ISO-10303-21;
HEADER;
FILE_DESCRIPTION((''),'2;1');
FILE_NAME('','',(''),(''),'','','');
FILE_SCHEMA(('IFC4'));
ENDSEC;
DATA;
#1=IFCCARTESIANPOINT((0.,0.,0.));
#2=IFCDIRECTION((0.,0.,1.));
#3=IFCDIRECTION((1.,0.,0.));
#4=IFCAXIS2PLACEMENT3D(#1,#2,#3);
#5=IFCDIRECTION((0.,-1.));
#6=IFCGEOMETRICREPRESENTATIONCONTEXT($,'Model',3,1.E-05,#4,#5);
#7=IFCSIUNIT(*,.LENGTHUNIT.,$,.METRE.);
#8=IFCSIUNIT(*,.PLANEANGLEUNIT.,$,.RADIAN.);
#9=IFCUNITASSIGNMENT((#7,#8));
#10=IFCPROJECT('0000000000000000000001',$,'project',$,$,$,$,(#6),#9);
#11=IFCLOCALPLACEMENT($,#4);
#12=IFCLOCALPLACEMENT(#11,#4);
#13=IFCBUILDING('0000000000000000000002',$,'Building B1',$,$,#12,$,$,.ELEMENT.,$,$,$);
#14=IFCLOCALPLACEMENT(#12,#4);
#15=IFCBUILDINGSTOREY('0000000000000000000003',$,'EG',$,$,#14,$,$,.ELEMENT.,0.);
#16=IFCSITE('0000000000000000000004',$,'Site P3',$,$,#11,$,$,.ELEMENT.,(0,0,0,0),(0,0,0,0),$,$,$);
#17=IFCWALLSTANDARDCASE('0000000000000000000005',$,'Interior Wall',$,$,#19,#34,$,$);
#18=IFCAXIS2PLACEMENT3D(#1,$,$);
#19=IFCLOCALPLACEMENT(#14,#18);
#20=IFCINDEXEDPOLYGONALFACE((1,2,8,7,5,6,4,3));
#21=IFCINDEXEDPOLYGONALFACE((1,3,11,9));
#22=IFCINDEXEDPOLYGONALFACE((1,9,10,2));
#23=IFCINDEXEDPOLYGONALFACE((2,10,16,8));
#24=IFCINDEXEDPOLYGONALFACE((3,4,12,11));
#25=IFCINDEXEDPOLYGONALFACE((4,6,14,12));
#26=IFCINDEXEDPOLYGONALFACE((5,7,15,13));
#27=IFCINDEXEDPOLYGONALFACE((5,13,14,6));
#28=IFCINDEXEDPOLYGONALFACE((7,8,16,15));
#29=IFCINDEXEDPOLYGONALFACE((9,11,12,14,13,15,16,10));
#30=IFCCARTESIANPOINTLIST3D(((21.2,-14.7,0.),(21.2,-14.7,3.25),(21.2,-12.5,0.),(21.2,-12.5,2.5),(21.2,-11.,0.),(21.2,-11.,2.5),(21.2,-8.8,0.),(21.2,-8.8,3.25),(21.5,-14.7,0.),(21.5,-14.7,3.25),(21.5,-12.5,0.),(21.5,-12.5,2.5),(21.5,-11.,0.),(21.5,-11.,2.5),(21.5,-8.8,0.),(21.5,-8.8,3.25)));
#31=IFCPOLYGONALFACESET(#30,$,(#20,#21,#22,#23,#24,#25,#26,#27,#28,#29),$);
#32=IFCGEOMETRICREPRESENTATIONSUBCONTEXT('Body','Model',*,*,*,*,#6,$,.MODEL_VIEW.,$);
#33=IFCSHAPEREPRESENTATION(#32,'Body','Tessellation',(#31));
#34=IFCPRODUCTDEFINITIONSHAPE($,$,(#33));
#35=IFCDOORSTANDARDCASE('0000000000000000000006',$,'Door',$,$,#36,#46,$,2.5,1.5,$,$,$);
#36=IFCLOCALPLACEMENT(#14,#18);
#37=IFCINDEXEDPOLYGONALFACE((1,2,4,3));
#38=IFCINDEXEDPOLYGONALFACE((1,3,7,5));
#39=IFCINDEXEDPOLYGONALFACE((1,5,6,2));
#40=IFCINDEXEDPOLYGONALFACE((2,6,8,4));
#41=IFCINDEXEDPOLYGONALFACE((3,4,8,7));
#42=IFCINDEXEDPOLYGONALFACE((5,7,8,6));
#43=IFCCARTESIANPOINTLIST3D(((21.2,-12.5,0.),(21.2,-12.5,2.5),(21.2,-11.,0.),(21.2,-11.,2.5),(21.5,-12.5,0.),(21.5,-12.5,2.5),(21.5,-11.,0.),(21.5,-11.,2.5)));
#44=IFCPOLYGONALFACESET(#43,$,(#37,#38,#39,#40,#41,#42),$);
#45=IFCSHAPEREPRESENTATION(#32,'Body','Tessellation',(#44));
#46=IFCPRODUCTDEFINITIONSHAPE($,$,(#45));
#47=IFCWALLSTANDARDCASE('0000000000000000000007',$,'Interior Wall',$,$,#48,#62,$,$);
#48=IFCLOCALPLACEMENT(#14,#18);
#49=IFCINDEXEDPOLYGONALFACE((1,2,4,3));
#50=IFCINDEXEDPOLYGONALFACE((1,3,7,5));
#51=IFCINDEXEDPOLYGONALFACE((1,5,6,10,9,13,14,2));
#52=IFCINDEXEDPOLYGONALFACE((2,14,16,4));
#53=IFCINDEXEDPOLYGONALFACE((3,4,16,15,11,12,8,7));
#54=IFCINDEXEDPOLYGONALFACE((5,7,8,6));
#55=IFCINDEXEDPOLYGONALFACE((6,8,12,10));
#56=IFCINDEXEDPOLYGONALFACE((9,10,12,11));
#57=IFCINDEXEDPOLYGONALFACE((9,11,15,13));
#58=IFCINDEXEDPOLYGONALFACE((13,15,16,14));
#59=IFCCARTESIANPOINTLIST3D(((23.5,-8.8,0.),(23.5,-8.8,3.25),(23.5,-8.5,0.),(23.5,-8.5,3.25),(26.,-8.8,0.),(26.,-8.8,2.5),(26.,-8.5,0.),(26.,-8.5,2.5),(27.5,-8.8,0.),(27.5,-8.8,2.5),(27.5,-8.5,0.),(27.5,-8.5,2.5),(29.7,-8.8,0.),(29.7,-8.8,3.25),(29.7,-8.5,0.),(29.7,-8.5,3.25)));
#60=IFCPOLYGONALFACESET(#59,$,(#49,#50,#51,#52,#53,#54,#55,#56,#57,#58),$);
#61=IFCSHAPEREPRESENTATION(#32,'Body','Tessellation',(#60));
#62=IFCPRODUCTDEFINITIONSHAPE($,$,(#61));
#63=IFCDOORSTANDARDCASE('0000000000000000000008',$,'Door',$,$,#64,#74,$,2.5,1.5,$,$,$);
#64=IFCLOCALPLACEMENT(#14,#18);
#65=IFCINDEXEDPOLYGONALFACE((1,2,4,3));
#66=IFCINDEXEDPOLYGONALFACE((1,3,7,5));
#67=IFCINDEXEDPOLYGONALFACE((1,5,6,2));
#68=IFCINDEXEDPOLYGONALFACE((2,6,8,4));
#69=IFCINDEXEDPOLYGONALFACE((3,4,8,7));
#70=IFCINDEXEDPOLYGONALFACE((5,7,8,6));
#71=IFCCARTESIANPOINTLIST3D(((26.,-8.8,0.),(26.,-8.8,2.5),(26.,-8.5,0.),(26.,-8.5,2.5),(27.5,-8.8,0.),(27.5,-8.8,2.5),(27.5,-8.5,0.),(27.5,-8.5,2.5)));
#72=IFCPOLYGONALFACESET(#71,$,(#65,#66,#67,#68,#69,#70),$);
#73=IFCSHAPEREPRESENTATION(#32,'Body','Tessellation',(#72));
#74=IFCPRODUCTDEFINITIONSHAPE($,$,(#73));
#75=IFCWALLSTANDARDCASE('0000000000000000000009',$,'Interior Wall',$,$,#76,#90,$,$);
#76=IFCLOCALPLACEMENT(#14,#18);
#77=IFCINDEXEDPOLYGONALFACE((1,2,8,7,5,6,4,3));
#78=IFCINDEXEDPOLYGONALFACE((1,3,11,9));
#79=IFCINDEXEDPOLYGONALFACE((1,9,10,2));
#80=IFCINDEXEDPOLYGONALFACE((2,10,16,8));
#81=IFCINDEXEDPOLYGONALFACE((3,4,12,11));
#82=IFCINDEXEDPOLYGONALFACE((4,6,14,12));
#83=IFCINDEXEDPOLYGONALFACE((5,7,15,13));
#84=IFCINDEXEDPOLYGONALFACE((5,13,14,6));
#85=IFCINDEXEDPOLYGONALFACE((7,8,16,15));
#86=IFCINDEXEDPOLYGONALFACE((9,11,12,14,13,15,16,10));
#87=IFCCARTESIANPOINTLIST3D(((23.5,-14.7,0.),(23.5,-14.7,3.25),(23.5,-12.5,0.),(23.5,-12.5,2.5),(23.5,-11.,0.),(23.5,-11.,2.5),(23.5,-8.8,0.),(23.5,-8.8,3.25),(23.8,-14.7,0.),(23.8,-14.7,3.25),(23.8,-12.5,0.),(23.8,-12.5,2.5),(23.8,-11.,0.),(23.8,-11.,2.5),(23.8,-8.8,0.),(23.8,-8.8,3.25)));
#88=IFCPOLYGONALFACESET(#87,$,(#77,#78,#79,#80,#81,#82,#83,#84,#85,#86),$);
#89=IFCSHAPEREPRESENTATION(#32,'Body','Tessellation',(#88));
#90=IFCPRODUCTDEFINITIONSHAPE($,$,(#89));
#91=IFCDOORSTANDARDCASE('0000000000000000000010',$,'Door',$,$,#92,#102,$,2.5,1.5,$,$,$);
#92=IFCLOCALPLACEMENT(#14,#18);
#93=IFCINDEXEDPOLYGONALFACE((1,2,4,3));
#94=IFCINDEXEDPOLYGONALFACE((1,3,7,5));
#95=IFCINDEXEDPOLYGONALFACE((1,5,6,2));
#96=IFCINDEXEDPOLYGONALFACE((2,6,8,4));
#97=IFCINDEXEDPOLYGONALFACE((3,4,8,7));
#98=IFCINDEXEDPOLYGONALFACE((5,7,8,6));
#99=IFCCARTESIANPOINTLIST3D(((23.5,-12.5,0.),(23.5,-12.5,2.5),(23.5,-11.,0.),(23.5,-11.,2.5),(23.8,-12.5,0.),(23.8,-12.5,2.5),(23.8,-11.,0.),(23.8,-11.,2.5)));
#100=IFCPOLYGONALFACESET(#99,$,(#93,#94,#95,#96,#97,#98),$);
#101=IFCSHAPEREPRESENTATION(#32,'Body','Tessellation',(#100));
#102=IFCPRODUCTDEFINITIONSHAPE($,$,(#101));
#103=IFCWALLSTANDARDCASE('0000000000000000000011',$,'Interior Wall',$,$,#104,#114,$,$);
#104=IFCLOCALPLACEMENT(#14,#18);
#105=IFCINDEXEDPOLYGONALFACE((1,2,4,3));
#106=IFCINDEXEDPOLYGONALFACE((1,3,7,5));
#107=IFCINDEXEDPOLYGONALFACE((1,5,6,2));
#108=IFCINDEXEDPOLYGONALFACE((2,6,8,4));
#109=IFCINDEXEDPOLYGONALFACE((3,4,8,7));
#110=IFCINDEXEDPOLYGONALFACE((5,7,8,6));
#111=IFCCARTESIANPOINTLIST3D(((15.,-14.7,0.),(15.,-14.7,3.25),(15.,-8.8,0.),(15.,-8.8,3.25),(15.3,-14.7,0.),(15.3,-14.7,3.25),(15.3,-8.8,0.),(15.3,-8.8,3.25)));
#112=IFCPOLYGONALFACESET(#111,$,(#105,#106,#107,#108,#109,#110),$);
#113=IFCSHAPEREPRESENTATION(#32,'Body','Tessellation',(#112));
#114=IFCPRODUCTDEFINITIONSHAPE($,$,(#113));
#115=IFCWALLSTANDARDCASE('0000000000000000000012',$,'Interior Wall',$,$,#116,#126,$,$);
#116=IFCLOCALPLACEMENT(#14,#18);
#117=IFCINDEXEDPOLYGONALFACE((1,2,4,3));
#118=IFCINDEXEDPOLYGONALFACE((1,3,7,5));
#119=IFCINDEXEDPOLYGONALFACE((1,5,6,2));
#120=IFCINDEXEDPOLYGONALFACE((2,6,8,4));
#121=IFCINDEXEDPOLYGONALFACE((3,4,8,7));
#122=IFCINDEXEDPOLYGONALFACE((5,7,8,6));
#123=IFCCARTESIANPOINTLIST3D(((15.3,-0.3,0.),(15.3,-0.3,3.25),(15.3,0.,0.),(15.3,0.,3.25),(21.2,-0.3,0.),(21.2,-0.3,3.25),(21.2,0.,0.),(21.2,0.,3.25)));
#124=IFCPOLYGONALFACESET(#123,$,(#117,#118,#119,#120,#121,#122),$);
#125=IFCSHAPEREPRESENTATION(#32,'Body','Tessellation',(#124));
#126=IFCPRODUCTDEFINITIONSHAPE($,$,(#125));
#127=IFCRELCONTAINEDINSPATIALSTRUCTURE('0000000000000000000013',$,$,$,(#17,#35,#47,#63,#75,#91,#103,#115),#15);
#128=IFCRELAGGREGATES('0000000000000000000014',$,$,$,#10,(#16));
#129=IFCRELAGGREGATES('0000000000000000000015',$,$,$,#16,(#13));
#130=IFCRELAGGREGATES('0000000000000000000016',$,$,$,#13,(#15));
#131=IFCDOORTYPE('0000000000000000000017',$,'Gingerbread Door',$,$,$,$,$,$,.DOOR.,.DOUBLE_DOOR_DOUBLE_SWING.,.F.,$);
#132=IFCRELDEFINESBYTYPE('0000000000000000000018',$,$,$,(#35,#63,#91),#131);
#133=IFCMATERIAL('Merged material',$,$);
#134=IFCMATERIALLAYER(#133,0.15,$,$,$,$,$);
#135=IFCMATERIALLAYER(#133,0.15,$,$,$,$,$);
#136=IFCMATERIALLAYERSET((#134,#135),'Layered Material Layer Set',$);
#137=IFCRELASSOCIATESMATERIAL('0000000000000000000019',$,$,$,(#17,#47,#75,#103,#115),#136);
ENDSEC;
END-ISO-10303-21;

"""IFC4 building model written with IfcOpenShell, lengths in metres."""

from ifc_helpers import new_model, si_unit, direction, frame, origin_with_axes, place, context, subcontext, project, spatial, polyline, outline, extrude, source, transform, mapped, material, layer, layer_set, layer_usage, type_object, element, fill, save


model = new_model("IFC4")

# Units and contexts
model_context = context("Model", 3, precision=1e-05, world=origin_with_axes(), true_north=direction((0.0, -1.0)))
body_context = subcontext(model_context, "Body", "Model", "MODEL_VIEW")
ifc_project = project(units=[si_unit("LENGTHUNIT", "METRE"), si_unit("PLANEANGLEUNIT", "RADIAN")], contexts=[model_context])

# Site, building, storey
site_placement = place(None, origin_with_axes())
site = spatial("IfcSite", under=ifc_project, at=site_placement, Name="Site P3", CompositionType="ELEMENT", RefLatitude=(0, 0, 0, 0), RefLongitude=(0, 0, 0, 0))
building_placement = place(site_placement, origin_with_axes())
building = spatial("IfcBuilding", under=site, at=building_placement, Name="Building B1", CompositionType="ELEMENT")
storey_placement = place(building_placement, origin_with_axes())
storey = spatial("IfcBuildingStorey", under=building, at=storey_placement, Name="EG", CompositionType="ELEMENT", Elevation=0.0)

# Shared definitions
ifc_material = material(Name="Merged material")

# Walls, openings, doors
ifc_layer_1 = layer(ifc_material, 0.15)
ifc_layer_2 = layer(ifc_material, 0.15)
ifc_layer_set_1 = layer_set([ifc_layer_1, ifc_layer_2], Name="Layered Material Layer Set")
ifc_layer_usage_1 = layer_usage(ifc_layer_set_1, "AXIS2", "POSITIVE", -0.15)
door_type = type_object("IfcDoorType", Name="Gingerbread Door", OperationType="DOUBLE_DOOR_DOUBLE_SWING", ParameterTakesPrecedence=False, PredefinedType="DOOR")
shared_shape_1 = source(origin_with_axes(), body_context, "Body", "SweptSolid", [
    extrude(outline(polyline([(0.0, 0.0), (0.0, 1.5), (2.5, 1.5), (2.5, 0.0), (0.0, 0.0)])), frame((0.0, -0.15, 0.0), z_axis=(0.0, 1.0, 0.0), x_axis=(0.0, 0.0, 1.0)), (0.0, 0.0, 1.0), 0.3),
])
wall_1_placement = place(storey_placement, frame((21.35, -8.8, 0.0), z_axis=(0.0, 0.0, 1.0), x_axis=(0.0, -1.0, 0.0)))
wall_1 = element("IfcWallStandardCase", 1, at=wall_1_placement, inside=storey, material=ifc_layer_usage_1, Name="Interior Wall", context=body_context, shape_type="SweptSolid", body=[
    extrude(outline(polyline([(0.0, 0.15), (5.9, 0.15), (5.9, -0.15), (0.0, -0.15), (0.0, 0.15)])), origin_with_axes(), (0.0, 0.0, 1.0), 3.25),
])
opening_1_placement = place(wall_1_placement, frame((2.2, 0.0, 0.0), z_axis=(0.0, 0.0, 1.0), x_axis=(1.0, 0.0, 0.0)))
opening_1 = element("IfcOpeningStandardCase", 2, at=opening_1_placement, cuts=wall_1, context=body_context, shape_type="SweptSolid", body=[
    extrude(outline(polyline([(0.0, 0.0), (0.0, 1.5), (2.5, 1.5), (2.5, 0.0), (0.0, 0.0)])), frame((0.0, -0.15, 0.0), z_axis=(0.0, 1.0, 0.0), x_axis=(0.0, 0.0, 1.0)), (0.0, 0.0, 1.0), 0.3),
])
door_1_placement = place(opening_1_placement, origin_with_axes())
door_1 = element("IfcDoorStandardCase", 3, at=door_1_placement, inside=storey, type_object=door_type, Name="Door", OverallHeight=2.5, OverallWidth=1.5, context=body_context, shape_type="MappedRepresentation", body=[
    mapped(shared_shape_1, transform((0.0, 0.0, 0.0))),
])
fill(opening_1, door_1)
wall_2_placement = place(storey_placement, frame((23.5, -8.65, 0.0), z_axis=(0.0, 0.0, 1.0), x_axis=(1.0, 0.0, 0.0)))
wall_2 = element("IfcWallStandardCase", 4, at=wall_2_placement, inside=storey, material=ifc_layer_usage_1, Name="Interior Wall", context=body_context, shape_type="SweptSolid", body=[
    extrude(outline(polyline([(0.0, 0.15), (6.2, 0.15), (6.2, -0.15), (0.0, -0.15), (0.0, 0.15)])), origin_with_axes(), (0.0, 0.0, 1.0), 3.25),
])
opening_2_placement = place(wall_2_placement, frame((2.5, 0.0, 0.0), z_axis=(0.0, 0.0, 1.0), x_axis=(1.0, 0.0, 0.0)))
opening_2 = element("IfcOpeningStandardCase", 5, at=opening_2_placement, cuts=wall_2, context=body_context, shape_type="SweptSolid", body=[
    extrude(outline(polyline([(0.0, 0.0), (0.0, 1.5), (2.5, 1.5), (2.5, 0.0), (0.0, 0.0)])), frame((0.0, -0.15, 0.0), z_axis=(0.0, 1.0, 0.0), x_axis=(0.0, 0.0, 1.0)), (0.0, 0.0, 1.0), 0.3),
])
door_2_placement = place(opening_2_placement, origin_with_axes())
door_2 = element("IfcDoorStandardCase", 6, at=door_2_placement, inside=storey, type_object=door_type, Name="Door", OverallHeight=2.5, OverallWidth=1.5, context=body_context, shape_type="MappedRepresentation", body=[
    mapped(shared_shape_1, transform((0.0, 0.0, 0.0))),
])
fill(opening_2, door_2)
wall_3_placement = place(storey_placement, frame((23.65, -8.8, 0.0), z_axis=(0.0, 0.0, 1.0), x_axis=(0.0, -1.0, 0.0)))
wall_3 = element("IfcWallStandardCase", 7, at=wall_3_placement, inside=storey, material=ifc_layer_usage_1, Name="Interior Wall", context=body_context, shape_type="SweptSolid", body=[
    extrude(outline(polyline([(0.0, 0.15), (5.9, 0.15), (5.9, -0.15), (0.0, -0.15), (0.0, 0.15)])), origin_with_axes(), (0.0, 0.0, 1.0), 3.25),
])
opening_3_placement = place(wall_3_placement, frame((2.2, 0.0, 0.0), z_axis=(0.0, 0.0, 1.0), x_axis=(1.0, 0.0, 0.0)))
opening_3 = element("IfcOpeningStandardCase", 8, at=opening_3_placement, cuts=wall_3, context=body_context, shape_type="SweptSolid", body=[
    extrude(outline(polyline([(0.0, 0.0), (0.0, 1.5), (2.5, 1.5), (2.5, 0.0), (0.0, 0.0)])), frame((0.0, -0.15, 0.0), z_axis=(0.0, 1.0, 0.0), x_axis=(0.0, 0.0, 1.0)), (0.0, 0.0, 1.0), 0.3),
])
door_3_placement = place(opening_3_placement, origin_with_axes())
door_3 = element("IfcDoorStandardCase", 9, at=door_3_placement, inside=storey, type_object=door_type, Name="Door", OverallHeight=2.5, OverallWidth=1.5, context=body_context, shape_type="MappedRepresentation", body=[
    mapped(shared_shape_1, transform((0.0, 0.0, 0.0))),
])
fill(opening_3, door_3)

# Walls
for number, where, z_axis, x_axis, name in (
    (10, (15.15, -8.8, 0.0), (0.0, 0.0, 1.0), (0.0, -1.0, 0.0), "Interior Wall"),
    (11, (15.3, -0.15, 0.0), (0.0, 0.0, 1.0), (1.0, 0.0, 0.0), "Interior Wall"),
):
    element("IfcWallStandardCase", number, at=place(storey_placement, frame(where, z_axis=z_axis, x_axis=x_axis)), inside=storey, material=ifc_layer_usage_1, Name=name, context=body_context, shape_type="SweptSolid", body=[
        extrude(outline(polyline([(0.0, 0.15), (5.9, 0.15), (5.9, -0.15), (0.0, -0.15), (0.0, 0.15)])), origin_with_axes(), (0.0, 0.0, 1.0), 3.25),
    ])

save(model, "model.ifc")
